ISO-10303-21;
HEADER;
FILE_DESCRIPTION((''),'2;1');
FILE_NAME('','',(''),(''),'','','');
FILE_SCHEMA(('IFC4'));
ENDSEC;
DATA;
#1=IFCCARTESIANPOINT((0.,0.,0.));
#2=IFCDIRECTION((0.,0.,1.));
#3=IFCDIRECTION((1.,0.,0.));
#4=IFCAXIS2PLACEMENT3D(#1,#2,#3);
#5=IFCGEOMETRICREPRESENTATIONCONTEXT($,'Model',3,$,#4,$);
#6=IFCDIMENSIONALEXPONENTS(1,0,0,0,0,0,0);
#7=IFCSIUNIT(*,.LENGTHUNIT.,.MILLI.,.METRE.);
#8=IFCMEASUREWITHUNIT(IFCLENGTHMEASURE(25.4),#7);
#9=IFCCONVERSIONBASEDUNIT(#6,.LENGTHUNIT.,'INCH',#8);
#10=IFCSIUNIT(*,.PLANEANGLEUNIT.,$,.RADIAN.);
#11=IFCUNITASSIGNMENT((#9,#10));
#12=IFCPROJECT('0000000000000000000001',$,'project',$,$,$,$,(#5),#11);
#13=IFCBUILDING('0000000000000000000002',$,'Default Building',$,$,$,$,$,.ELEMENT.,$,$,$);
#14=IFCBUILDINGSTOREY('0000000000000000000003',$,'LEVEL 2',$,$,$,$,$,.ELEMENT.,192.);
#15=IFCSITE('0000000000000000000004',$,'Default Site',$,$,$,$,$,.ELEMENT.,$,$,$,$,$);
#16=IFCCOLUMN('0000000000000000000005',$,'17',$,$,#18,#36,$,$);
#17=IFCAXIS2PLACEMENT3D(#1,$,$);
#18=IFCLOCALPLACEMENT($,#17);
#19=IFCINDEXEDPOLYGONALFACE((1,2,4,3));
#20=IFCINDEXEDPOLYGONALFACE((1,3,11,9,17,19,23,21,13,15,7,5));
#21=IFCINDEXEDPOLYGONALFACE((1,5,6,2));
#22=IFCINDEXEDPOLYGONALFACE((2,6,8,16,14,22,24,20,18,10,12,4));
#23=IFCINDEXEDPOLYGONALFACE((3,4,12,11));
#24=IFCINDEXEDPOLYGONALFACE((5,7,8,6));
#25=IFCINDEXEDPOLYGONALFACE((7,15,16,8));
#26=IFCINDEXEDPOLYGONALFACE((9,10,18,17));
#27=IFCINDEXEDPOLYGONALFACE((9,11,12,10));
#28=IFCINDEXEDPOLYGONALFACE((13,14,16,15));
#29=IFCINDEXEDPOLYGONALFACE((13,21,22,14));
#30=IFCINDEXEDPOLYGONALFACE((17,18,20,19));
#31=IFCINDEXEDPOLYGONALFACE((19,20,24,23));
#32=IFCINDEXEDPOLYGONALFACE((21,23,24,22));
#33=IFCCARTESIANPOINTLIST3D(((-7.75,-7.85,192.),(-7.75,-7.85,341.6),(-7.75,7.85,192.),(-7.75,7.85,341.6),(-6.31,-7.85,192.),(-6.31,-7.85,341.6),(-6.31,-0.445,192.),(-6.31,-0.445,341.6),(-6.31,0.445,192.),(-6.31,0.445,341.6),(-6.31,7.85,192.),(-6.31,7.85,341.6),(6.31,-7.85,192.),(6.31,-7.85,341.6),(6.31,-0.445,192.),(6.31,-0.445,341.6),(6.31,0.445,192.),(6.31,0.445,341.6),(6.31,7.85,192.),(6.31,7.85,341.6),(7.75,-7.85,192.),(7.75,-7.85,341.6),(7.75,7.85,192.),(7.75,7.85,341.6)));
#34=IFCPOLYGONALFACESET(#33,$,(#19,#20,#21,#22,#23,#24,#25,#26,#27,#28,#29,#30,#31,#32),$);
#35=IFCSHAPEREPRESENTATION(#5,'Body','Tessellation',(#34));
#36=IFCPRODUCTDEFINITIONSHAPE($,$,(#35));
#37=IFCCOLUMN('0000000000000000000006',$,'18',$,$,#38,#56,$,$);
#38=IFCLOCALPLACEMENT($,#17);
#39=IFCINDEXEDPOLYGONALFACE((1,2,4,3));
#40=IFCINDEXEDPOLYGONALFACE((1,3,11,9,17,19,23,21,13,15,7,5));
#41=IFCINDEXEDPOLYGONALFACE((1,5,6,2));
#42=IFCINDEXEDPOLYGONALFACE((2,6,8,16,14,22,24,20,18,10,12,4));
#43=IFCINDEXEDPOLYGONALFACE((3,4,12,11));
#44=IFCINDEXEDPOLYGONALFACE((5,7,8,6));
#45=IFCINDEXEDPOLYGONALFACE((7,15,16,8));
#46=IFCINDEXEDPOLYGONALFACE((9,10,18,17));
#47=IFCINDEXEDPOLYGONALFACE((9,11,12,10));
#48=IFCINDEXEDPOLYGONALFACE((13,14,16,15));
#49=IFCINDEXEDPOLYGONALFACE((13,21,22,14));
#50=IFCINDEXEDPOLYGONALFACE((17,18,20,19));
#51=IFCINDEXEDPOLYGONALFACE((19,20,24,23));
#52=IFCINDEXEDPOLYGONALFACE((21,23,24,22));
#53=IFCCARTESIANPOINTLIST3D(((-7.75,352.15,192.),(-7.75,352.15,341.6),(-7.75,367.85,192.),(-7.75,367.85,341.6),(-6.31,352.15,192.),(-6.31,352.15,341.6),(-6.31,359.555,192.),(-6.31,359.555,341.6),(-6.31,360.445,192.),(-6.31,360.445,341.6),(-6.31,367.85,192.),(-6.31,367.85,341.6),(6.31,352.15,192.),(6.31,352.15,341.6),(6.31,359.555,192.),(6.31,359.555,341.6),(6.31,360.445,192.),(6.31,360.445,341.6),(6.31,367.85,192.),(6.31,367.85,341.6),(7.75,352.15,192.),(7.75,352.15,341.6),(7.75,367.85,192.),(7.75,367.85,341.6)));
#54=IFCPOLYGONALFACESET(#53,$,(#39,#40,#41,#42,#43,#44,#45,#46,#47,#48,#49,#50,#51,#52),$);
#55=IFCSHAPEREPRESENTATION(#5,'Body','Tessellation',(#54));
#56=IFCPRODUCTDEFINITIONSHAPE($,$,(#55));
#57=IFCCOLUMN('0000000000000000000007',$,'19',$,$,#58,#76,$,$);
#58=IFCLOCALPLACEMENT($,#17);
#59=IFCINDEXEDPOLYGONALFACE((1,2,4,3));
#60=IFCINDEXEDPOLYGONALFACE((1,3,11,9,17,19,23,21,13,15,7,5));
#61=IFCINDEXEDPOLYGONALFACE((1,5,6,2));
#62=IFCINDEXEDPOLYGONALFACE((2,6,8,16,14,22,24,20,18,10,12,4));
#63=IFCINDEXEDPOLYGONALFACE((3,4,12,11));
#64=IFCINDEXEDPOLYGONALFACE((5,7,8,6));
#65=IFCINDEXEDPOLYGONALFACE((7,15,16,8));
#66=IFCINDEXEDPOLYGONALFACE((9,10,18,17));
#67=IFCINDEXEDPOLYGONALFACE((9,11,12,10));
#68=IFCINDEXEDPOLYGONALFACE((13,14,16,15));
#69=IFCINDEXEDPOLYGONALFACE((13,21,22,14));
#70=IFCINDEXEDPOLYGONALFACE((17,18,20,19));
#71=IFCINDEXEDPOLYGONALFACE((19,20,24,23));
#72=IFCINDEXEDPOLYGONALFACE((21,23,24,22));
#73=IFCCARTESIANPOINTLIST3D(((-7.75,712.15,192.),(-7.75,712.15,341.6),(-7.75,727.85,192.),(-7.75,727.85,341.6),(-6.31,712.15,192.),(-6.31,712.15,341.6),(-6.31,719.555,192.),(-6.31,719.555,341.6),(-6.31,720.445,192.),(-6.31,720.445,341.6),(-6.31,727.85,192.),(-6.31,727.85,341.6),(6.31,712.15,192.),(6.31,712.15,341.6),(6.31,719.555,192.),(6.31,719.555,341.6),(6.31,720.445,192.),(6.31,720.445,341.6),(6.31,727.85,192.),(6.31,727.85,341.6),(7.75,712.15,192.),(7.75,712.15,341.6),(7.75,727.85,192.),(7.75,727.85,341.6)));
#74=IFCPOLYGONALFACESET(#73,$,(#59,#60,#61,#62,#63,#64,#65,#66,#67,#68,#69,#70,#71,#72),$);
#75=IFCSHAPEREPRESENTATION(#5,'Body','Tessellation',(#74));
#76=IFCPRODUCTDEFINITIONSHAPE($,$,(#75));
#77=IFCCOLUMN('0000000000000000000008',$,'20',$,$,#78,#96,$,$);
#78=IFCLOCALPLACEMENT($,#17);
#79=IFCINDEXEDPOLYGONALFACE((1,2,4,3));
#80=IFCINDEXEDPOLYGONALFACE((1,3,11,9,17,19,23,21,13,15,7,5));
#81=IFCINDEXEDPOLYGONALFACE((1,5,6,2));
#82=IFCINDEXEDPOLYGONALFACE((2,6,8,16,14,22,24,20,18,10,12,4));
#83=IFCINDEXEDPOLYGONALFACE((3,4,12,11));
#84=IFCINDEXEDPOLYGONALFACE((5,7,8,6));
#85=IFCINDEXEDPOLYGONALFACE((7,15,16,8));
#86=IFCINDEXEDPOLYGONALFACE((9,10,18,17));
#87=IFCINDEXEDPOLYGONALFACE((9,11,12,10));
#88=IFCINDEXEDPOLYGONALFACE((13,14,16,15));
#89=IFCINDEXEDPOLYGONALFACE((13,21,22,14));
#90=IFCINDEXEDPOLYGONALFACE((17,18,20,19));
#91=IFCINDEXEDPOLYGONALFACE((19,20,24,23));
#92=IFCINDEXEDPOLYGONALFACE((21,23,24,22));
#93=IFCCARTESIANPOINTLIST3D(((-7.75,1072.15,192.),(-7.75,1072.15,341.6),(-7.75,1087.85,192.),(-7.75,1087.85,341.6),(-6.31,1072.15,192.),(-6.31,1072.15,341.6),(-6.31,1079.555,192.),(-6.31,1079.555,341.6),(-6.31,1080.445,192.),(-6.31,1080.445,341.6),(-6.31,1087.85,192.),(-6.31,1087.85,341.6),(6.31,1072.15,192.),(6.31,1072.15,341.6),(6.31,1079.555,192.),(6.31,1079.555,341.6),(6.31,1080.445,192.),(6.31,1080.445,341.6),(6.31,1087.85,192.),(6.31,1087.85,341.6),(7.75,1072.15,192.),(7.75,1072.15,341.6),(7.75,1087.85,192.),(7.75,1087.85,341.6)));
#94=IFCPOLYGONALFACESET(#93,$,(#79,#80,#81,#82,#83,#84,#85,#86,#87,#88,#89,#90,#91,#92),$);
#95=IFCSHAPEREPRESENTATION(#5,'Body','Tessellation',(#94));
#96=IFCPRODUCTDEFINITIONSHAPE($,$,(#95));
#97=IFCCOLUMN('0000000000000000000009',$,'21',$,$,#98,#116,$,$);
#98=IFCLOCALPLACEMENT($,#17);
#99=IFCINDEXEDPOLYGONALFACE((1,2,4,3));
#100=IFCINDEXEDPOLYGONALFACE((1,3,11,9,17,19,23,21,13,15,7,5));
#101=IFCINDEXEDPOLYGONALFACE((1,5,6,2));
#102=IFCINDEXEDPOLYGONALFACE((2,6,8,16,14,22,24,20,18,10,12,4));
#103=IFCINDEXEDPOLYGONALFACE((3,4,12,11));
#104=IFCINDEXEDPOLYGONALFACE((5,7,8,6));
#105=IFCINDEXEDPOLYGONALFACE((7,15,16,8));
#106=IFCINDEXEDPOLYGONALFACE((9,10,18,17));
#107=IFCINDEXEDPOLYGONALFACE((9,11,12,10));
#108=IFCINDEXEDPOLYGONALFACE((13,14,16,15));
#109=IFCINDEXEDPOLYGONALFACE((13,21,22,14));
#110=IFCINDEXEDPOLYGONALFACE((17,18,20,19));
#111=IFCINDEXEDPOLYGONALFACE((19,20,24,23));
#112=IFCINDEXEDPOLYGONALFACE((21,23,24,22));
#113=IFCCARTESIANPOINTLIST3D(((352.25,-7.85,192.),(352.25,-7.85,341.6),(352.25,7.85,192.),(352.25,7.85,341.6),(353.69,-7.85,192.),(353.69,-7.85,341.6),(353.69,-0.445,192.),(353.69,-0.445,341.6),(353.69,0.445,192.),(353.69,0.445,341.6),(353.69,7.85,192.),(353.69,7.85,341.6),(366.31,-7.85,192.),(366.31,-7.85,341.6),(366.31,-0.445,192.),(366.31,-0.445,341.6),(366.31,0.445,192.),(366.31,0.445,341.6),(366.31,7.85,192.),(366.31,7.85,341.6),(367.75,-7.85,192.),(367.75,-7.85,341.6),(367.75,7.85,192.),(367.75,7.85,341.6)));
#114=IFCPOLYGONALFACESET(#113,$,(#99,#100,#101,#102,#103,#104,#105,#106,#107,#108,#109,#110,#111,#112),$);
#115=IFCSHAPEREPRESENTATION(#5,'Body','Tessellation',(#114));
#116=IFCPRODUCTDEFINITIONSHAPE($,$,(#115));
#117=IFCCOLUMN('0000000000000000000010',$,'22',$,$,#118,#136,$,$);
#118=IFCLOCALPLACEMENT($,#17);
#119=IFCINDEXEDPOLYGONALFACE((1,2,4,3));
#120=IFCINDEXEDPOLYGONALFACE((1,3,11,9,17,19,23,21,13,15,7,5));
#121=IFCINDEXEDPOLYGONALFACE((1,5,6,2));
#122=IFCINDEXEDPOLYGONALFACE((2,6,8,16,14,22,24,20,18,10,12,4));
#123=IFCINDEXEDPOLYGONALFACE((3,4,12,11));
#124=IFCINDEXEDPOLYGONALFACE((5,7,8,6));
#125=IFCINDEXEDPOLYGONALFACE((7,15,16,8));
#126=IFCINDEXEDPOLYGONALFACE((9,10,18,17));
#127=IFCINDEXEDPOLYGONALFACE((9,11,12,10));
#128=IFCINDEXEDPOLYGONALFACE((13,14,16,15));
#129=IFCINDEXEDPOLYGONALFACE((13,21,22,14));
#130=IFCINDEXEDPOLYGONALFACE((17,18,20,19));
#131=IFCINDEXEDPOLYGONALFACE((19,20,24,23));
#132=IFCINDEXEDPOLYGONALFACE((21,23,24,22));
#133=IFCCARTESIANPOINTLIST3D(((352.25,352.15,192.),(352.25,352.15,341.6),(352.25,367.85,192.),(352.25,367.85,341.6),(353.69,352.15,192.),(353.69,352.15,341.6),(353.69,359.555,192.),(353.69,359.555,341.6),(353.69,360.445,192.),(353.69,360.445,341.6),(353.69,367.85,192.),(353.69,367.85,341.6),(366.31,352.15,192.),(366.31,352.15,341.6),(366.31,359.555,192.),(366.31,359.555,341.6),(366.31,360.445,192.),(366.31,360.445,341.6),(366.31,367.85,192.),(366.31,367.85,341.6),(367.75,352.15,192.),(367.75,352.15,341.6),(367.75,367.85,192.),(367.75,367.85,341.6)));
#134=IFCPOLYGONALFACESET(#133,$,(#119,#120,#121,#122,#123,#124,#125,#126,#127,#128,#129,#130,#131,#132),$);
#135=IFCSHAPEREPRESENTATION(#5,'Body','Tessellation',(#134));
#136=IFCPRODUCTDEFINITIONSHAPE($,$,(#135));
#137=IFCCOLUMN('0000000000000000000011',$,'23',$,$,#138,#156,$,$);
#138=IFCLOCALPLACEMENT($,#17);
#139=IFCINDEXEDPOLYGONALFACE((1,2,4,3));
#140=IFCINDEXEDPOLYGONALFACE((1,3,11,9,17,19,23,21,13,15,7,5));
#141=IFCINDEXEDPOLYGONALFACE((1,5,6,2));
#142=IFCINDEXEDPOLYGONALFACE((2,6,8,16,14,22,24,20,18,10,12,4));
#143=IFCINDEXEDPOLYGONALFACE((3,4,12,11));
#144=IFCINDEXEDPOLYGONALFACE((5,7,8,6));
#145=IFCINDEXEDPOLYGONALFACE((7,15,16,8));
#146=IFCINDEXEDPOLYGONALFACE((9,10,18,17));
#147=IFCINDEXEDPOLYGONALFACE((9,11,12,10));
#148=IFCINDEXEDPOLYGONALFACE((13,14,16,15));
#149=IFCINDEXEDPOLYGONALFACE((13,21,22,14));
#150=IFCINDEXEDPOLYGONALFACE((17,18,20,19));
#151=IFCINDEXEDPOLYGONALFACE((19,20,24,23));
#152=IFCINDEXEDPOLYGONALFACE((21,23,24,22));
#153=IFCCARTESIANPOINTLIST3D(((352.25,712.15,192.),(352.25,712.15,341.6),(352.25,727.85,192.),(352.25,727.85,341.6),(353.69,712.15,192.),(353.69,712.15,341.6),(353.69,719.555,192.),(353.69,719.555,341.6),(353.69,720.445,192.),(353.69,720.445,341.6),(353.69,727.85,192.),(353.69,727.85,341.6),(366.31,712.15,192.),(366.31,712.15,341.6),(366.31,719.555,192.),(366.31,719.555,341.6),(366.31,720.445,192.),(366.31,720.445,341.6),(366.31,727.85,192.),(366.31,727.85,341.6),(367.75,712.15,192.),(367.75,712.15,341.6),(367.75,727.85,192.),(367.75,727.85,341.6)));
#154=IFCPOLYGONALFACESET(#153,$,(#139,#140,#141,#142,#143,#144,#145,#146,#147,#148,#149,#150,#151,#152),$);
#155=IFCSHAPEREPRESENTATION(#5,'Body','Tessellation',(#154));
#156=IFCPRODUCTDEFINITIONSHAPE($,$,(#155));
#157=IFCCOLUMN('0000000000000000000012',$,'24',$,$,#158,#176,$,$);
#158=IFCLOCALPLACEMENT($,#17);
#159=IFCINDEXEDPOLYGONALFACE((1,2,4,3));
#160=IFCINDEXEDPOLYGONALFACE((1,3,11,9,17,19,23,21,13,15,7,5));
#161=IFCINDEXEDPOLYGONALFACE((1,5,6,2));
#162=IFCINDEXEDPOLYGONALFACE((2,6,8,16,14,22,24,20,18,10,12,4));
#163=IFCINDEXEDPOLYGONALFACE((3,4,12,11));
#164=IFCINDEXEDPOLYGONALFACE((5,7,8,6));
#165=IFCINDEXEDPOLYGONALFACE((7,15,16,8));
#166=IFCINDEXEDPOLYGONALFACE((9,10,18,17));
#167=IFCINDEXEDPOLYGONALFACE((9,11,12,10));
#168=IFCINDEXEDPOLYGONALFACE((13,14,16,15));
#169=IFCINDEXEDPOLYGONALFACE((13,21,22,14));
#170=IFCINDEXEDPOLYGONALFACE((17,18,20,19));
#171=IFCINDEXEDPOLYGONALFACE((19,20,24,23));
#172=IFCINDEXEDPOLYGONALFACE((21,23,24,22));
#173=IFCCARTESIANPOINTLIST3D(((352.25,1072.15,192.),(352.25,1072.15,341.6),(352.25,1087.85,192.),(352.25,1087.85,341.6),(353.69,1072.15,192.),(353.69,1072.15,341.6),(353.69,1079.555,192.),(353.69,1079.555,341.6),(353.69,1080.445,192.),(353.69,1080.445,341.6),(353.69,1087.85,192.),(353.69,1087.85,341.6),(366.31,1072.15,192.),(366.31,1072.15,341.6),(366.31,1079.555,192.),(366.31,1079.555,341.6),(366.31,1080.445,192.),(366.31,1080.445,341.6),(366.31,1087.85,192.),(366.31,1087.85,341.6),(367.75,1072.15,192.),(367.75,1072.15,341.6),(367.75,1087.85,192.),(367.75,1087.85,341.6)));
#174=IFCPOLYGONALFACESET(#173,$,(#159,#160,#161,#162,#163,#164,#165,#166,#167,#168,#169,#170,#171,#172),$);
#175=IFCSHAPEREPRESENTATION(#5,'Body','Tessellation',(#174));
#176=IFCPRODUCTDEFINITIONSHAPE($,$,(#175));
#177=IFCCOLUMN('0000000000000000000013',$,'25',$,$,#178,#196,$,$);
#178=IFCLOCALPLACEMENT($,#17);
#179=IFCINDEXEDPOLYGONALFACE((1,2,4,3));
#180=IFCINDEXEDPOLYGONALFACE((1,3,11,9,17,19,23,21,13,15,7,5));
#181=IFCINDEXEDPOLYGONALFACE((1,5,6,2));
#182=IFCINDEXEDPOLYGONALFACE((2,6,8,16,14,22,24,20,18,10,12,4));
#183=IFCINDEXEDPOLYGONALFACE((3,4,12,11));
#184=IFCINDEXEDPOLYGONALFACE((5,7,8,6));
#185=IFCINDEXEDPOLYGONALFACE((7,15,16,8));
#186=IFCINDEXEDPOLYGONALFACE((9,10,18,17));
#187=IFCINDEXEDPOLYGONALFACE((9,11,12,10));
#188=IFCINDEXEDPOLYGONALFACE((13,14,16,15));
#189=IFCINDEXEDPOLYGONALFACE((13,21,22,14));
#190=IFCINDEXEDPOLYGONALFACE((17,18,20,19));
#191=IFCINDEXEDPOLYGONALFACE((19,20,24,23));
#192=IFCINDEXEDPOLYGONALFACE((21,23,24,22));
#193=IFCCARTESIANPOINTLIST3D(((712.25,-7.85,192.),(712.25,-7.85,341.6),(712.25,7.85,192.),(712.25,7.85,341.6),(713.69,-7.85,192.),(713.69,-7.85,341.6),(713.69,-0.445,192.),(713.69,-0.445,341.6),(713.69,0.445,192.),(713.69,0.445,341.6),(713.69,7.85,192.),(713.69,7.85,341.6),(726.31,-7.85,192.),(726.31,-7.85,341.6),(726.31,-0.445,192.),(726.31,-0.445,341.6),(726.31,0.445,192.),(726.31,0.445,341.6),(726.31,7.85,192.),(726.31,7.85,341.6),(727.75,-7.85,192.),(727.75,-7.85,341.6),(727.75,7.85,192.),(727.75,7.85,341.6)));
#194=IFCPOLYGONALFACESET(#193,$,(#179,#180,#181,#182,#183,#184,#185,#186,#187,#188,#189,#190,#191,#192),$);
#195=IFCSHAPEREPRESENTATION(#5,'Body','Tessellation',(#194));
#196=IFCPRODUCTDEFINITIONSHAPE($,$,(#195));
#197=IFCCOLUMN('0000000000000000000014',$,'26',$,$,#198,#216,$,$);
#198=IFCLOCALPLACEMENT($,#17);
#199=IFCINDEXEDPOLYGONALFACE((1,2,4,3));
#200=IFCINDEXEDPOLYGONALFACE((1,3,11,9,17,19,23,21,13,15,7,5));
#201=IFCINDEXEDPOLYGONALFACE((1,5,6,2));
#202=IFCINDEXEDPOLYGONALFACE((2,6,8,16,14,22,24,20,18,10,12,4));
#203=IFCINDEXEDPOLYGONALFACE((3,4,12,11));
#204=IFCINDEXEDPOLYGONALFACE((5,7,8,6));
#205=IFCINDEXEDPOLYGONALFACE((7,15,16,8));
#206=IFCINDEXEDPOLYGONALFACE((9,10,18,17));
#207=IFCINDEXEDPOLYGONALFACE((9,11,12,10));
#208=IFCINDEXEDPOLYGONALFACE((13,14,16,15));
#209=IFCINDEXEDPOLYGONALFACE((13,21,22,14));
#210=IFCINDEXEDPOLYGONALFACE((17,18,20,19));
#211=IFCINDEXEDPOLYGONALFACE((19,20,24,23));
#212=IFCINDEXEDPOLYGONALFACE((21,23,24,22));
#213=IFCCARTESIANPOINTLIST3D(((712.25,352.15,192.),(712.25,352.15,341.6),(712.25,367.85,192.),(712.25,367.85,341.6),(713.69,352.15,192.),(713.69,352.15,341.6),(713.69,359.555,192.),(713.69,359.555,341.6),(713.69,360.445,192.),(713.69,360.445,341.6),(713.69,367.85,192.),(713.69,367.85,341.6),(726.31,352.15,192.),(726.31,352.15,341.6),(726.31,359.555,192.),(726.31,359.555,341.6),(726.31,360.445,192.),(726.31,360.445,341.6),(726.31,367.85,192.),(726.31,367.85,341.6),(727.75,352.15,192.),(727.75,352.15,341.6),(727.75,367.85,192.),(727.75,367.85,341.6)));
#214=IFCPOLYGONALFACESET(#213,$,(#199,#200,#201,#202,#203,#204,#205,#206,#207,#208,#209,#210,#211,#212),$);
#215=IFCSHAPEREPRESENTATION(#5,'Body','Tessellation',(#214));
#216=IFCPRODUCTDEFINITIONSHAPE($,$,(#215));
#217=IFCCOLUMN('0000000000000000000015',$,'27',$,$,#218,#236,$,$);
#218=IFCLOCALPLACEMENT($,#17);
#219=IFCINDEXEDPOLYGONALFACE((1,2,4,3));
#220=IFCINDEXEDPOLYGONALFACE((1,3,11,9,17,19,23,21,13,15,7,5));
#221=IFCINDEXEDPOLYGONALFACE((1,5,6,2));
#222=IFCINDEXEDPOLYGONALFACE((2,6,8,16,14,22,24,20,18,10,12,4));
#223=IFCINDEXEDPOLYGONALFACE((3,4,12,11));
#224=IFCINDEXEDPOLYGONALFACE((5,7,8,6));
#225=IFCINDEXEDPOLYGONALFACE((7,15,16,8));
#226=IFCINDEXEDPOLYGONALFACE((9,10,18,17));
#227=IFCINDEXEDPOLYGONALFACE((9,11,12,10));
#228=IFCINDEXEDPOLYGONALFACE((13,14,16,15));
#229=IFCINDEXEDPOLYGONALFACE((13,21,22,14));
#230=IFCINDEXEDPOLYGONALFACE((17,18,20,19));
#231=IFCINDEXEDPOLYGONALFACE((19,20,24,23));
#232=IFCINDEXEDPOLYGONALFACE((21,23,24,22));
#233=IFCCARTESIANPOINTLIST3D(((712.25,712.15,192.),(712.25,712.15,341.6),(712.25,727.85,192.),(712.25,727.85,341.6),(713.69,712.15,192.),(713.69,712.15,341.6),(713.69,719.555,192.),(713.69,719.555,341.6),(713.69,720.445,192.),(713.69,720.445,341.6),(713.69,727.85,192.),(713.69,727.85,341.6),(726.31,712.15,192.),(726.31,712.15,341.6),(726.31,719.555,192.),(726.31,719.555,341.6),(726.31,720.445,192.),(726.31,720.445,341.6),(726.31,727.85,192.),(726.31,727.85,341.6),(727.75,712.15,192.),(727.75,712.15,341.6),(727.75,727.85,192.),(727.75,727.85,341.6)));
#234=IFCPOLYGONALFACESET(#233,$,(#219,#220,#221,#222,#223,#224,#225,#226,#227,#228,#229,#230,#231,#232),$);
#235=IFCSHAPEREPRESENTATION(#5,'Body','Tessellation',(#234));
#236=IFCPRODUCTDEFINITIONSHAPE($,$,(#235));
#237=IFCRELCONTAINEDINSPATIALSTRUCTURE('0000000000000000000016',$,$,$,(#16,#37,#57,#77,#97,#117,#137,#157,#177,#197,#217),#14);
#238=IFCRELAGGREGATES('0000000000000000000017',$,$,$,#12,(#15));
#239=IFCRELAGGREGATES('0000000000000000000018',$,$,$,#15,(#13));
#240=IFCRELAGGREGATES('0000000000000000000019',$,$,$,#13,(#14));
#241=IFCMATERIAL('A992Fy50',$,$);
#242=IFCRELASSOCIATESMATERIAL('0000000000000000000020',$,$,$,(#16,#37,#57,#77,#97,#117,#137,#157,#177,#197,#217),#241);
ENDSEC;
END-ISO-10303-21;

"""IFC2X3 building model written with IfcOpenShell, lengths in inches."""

from ifc_helpers import new_model, entity, si_unit, converted_unit, frame, origin_with_axes, origin_2d_with_axis, place, context, project, spatial, i_section, extrude, material, element, save


model = new_model("IFC2X3")

# Units and contexts
model_context = context("Model", 3, world=origin_with_axes())
ifc_project = project(units=[converted_unit("LENGTHUNIT", "INCH", entity("IfcLengthMeasure", 25.4), si_unit("LENGTHUNIT", "METRE", prefix="MILLI"), dimensions=[1, 0, 0, 0, 0, 0, 0]), si_unit("PLANEANGLEUNIT", "RADIAN")], contexts=[model_context])

# Site, building, storey
site = spatial("IfcSite", under=ifc_project, Name="Default Site", CompositionType="ELEMENT")
building = spatial("IfcBuilding", under=site, Name="Default Building", CompositionType="ELEMENT")
storey = spatial("IfcBuildingStorey", under=building, Name="LEVEL 2", CompositionType="ELEMENT", Elevation=192.0)

# Columns
ifc_material = material(Name="A992Fy50")
for number, where, z_axis, x_axis, name in (
    (1, (0.0, 0.0, 192.0), (0.0, 0.0, 1.0), (0.0, -1.0, 0.0), "17"),
    (2, (0.0, 360.0, 192.0), (0.0, 0.0, 1.0), (0.0, -1.0, 0.0), "18"),
    (3, (0.0, 720.0, 192.0), (0.0, 0.0, 1.0), (0.0, -1.0, 0.0), "19"),
    (4, (0.0, 1080.0, 192.0), (0.0, 0.0, 1.0), (0.0, -1.0, 0.0), "20"),
    (5, (360.0, 0.0, 192.0), (0.0, 0.0, 1.0), (0.0, -1.0, 0.0), "21"),
    (6, (360.0, 360.0, 192.0), (0.0, 0.0, 1.0), (0.0, -1.0, 0.0), "22"),
    (7, (360.0, 720.0, 192.0), (0.0, 0.0, 1.0), (0.0, -1.0, 0.0), "23"),
    (8, (360.0, 1080.0, 192.0), (0.0, 0.0, 1.0), (0.0, -1.0, 0.0), "24"),
    (9, (720.0, 0.0, 192.0), (0.0, 0.0, 1.0), (0.0, -1.0, 0.0), "25"),
    (10, (720.0, 360.0, 192.0), (0.0, 0.0, 1.0), (0.0, -1.0, 0.0), "26"),
    (11, (720.0, 720.0, 192.0), (0.0, 0.0, 1.0), (0.0, -1.0, 0.0), "27"),
):
    element("IfcColumn", number, at=place(None, frame(where, z_axis=z_axis, x_axis=x_axis)), inside=storey, material=ifc_material, Name=name, context=model_context, shape_type="SweptSolid", body=[
        extrude(i_section(OverallWidth=15.7, OverallDepth=15.5, WebThickness=0.89, FlangeThickness=1.44, at=origin_2d_with_axis()), origin_with_axes(), (0.0, 0.0, 1.0), 149.6),
    ])

save(model, "model.ifc")
